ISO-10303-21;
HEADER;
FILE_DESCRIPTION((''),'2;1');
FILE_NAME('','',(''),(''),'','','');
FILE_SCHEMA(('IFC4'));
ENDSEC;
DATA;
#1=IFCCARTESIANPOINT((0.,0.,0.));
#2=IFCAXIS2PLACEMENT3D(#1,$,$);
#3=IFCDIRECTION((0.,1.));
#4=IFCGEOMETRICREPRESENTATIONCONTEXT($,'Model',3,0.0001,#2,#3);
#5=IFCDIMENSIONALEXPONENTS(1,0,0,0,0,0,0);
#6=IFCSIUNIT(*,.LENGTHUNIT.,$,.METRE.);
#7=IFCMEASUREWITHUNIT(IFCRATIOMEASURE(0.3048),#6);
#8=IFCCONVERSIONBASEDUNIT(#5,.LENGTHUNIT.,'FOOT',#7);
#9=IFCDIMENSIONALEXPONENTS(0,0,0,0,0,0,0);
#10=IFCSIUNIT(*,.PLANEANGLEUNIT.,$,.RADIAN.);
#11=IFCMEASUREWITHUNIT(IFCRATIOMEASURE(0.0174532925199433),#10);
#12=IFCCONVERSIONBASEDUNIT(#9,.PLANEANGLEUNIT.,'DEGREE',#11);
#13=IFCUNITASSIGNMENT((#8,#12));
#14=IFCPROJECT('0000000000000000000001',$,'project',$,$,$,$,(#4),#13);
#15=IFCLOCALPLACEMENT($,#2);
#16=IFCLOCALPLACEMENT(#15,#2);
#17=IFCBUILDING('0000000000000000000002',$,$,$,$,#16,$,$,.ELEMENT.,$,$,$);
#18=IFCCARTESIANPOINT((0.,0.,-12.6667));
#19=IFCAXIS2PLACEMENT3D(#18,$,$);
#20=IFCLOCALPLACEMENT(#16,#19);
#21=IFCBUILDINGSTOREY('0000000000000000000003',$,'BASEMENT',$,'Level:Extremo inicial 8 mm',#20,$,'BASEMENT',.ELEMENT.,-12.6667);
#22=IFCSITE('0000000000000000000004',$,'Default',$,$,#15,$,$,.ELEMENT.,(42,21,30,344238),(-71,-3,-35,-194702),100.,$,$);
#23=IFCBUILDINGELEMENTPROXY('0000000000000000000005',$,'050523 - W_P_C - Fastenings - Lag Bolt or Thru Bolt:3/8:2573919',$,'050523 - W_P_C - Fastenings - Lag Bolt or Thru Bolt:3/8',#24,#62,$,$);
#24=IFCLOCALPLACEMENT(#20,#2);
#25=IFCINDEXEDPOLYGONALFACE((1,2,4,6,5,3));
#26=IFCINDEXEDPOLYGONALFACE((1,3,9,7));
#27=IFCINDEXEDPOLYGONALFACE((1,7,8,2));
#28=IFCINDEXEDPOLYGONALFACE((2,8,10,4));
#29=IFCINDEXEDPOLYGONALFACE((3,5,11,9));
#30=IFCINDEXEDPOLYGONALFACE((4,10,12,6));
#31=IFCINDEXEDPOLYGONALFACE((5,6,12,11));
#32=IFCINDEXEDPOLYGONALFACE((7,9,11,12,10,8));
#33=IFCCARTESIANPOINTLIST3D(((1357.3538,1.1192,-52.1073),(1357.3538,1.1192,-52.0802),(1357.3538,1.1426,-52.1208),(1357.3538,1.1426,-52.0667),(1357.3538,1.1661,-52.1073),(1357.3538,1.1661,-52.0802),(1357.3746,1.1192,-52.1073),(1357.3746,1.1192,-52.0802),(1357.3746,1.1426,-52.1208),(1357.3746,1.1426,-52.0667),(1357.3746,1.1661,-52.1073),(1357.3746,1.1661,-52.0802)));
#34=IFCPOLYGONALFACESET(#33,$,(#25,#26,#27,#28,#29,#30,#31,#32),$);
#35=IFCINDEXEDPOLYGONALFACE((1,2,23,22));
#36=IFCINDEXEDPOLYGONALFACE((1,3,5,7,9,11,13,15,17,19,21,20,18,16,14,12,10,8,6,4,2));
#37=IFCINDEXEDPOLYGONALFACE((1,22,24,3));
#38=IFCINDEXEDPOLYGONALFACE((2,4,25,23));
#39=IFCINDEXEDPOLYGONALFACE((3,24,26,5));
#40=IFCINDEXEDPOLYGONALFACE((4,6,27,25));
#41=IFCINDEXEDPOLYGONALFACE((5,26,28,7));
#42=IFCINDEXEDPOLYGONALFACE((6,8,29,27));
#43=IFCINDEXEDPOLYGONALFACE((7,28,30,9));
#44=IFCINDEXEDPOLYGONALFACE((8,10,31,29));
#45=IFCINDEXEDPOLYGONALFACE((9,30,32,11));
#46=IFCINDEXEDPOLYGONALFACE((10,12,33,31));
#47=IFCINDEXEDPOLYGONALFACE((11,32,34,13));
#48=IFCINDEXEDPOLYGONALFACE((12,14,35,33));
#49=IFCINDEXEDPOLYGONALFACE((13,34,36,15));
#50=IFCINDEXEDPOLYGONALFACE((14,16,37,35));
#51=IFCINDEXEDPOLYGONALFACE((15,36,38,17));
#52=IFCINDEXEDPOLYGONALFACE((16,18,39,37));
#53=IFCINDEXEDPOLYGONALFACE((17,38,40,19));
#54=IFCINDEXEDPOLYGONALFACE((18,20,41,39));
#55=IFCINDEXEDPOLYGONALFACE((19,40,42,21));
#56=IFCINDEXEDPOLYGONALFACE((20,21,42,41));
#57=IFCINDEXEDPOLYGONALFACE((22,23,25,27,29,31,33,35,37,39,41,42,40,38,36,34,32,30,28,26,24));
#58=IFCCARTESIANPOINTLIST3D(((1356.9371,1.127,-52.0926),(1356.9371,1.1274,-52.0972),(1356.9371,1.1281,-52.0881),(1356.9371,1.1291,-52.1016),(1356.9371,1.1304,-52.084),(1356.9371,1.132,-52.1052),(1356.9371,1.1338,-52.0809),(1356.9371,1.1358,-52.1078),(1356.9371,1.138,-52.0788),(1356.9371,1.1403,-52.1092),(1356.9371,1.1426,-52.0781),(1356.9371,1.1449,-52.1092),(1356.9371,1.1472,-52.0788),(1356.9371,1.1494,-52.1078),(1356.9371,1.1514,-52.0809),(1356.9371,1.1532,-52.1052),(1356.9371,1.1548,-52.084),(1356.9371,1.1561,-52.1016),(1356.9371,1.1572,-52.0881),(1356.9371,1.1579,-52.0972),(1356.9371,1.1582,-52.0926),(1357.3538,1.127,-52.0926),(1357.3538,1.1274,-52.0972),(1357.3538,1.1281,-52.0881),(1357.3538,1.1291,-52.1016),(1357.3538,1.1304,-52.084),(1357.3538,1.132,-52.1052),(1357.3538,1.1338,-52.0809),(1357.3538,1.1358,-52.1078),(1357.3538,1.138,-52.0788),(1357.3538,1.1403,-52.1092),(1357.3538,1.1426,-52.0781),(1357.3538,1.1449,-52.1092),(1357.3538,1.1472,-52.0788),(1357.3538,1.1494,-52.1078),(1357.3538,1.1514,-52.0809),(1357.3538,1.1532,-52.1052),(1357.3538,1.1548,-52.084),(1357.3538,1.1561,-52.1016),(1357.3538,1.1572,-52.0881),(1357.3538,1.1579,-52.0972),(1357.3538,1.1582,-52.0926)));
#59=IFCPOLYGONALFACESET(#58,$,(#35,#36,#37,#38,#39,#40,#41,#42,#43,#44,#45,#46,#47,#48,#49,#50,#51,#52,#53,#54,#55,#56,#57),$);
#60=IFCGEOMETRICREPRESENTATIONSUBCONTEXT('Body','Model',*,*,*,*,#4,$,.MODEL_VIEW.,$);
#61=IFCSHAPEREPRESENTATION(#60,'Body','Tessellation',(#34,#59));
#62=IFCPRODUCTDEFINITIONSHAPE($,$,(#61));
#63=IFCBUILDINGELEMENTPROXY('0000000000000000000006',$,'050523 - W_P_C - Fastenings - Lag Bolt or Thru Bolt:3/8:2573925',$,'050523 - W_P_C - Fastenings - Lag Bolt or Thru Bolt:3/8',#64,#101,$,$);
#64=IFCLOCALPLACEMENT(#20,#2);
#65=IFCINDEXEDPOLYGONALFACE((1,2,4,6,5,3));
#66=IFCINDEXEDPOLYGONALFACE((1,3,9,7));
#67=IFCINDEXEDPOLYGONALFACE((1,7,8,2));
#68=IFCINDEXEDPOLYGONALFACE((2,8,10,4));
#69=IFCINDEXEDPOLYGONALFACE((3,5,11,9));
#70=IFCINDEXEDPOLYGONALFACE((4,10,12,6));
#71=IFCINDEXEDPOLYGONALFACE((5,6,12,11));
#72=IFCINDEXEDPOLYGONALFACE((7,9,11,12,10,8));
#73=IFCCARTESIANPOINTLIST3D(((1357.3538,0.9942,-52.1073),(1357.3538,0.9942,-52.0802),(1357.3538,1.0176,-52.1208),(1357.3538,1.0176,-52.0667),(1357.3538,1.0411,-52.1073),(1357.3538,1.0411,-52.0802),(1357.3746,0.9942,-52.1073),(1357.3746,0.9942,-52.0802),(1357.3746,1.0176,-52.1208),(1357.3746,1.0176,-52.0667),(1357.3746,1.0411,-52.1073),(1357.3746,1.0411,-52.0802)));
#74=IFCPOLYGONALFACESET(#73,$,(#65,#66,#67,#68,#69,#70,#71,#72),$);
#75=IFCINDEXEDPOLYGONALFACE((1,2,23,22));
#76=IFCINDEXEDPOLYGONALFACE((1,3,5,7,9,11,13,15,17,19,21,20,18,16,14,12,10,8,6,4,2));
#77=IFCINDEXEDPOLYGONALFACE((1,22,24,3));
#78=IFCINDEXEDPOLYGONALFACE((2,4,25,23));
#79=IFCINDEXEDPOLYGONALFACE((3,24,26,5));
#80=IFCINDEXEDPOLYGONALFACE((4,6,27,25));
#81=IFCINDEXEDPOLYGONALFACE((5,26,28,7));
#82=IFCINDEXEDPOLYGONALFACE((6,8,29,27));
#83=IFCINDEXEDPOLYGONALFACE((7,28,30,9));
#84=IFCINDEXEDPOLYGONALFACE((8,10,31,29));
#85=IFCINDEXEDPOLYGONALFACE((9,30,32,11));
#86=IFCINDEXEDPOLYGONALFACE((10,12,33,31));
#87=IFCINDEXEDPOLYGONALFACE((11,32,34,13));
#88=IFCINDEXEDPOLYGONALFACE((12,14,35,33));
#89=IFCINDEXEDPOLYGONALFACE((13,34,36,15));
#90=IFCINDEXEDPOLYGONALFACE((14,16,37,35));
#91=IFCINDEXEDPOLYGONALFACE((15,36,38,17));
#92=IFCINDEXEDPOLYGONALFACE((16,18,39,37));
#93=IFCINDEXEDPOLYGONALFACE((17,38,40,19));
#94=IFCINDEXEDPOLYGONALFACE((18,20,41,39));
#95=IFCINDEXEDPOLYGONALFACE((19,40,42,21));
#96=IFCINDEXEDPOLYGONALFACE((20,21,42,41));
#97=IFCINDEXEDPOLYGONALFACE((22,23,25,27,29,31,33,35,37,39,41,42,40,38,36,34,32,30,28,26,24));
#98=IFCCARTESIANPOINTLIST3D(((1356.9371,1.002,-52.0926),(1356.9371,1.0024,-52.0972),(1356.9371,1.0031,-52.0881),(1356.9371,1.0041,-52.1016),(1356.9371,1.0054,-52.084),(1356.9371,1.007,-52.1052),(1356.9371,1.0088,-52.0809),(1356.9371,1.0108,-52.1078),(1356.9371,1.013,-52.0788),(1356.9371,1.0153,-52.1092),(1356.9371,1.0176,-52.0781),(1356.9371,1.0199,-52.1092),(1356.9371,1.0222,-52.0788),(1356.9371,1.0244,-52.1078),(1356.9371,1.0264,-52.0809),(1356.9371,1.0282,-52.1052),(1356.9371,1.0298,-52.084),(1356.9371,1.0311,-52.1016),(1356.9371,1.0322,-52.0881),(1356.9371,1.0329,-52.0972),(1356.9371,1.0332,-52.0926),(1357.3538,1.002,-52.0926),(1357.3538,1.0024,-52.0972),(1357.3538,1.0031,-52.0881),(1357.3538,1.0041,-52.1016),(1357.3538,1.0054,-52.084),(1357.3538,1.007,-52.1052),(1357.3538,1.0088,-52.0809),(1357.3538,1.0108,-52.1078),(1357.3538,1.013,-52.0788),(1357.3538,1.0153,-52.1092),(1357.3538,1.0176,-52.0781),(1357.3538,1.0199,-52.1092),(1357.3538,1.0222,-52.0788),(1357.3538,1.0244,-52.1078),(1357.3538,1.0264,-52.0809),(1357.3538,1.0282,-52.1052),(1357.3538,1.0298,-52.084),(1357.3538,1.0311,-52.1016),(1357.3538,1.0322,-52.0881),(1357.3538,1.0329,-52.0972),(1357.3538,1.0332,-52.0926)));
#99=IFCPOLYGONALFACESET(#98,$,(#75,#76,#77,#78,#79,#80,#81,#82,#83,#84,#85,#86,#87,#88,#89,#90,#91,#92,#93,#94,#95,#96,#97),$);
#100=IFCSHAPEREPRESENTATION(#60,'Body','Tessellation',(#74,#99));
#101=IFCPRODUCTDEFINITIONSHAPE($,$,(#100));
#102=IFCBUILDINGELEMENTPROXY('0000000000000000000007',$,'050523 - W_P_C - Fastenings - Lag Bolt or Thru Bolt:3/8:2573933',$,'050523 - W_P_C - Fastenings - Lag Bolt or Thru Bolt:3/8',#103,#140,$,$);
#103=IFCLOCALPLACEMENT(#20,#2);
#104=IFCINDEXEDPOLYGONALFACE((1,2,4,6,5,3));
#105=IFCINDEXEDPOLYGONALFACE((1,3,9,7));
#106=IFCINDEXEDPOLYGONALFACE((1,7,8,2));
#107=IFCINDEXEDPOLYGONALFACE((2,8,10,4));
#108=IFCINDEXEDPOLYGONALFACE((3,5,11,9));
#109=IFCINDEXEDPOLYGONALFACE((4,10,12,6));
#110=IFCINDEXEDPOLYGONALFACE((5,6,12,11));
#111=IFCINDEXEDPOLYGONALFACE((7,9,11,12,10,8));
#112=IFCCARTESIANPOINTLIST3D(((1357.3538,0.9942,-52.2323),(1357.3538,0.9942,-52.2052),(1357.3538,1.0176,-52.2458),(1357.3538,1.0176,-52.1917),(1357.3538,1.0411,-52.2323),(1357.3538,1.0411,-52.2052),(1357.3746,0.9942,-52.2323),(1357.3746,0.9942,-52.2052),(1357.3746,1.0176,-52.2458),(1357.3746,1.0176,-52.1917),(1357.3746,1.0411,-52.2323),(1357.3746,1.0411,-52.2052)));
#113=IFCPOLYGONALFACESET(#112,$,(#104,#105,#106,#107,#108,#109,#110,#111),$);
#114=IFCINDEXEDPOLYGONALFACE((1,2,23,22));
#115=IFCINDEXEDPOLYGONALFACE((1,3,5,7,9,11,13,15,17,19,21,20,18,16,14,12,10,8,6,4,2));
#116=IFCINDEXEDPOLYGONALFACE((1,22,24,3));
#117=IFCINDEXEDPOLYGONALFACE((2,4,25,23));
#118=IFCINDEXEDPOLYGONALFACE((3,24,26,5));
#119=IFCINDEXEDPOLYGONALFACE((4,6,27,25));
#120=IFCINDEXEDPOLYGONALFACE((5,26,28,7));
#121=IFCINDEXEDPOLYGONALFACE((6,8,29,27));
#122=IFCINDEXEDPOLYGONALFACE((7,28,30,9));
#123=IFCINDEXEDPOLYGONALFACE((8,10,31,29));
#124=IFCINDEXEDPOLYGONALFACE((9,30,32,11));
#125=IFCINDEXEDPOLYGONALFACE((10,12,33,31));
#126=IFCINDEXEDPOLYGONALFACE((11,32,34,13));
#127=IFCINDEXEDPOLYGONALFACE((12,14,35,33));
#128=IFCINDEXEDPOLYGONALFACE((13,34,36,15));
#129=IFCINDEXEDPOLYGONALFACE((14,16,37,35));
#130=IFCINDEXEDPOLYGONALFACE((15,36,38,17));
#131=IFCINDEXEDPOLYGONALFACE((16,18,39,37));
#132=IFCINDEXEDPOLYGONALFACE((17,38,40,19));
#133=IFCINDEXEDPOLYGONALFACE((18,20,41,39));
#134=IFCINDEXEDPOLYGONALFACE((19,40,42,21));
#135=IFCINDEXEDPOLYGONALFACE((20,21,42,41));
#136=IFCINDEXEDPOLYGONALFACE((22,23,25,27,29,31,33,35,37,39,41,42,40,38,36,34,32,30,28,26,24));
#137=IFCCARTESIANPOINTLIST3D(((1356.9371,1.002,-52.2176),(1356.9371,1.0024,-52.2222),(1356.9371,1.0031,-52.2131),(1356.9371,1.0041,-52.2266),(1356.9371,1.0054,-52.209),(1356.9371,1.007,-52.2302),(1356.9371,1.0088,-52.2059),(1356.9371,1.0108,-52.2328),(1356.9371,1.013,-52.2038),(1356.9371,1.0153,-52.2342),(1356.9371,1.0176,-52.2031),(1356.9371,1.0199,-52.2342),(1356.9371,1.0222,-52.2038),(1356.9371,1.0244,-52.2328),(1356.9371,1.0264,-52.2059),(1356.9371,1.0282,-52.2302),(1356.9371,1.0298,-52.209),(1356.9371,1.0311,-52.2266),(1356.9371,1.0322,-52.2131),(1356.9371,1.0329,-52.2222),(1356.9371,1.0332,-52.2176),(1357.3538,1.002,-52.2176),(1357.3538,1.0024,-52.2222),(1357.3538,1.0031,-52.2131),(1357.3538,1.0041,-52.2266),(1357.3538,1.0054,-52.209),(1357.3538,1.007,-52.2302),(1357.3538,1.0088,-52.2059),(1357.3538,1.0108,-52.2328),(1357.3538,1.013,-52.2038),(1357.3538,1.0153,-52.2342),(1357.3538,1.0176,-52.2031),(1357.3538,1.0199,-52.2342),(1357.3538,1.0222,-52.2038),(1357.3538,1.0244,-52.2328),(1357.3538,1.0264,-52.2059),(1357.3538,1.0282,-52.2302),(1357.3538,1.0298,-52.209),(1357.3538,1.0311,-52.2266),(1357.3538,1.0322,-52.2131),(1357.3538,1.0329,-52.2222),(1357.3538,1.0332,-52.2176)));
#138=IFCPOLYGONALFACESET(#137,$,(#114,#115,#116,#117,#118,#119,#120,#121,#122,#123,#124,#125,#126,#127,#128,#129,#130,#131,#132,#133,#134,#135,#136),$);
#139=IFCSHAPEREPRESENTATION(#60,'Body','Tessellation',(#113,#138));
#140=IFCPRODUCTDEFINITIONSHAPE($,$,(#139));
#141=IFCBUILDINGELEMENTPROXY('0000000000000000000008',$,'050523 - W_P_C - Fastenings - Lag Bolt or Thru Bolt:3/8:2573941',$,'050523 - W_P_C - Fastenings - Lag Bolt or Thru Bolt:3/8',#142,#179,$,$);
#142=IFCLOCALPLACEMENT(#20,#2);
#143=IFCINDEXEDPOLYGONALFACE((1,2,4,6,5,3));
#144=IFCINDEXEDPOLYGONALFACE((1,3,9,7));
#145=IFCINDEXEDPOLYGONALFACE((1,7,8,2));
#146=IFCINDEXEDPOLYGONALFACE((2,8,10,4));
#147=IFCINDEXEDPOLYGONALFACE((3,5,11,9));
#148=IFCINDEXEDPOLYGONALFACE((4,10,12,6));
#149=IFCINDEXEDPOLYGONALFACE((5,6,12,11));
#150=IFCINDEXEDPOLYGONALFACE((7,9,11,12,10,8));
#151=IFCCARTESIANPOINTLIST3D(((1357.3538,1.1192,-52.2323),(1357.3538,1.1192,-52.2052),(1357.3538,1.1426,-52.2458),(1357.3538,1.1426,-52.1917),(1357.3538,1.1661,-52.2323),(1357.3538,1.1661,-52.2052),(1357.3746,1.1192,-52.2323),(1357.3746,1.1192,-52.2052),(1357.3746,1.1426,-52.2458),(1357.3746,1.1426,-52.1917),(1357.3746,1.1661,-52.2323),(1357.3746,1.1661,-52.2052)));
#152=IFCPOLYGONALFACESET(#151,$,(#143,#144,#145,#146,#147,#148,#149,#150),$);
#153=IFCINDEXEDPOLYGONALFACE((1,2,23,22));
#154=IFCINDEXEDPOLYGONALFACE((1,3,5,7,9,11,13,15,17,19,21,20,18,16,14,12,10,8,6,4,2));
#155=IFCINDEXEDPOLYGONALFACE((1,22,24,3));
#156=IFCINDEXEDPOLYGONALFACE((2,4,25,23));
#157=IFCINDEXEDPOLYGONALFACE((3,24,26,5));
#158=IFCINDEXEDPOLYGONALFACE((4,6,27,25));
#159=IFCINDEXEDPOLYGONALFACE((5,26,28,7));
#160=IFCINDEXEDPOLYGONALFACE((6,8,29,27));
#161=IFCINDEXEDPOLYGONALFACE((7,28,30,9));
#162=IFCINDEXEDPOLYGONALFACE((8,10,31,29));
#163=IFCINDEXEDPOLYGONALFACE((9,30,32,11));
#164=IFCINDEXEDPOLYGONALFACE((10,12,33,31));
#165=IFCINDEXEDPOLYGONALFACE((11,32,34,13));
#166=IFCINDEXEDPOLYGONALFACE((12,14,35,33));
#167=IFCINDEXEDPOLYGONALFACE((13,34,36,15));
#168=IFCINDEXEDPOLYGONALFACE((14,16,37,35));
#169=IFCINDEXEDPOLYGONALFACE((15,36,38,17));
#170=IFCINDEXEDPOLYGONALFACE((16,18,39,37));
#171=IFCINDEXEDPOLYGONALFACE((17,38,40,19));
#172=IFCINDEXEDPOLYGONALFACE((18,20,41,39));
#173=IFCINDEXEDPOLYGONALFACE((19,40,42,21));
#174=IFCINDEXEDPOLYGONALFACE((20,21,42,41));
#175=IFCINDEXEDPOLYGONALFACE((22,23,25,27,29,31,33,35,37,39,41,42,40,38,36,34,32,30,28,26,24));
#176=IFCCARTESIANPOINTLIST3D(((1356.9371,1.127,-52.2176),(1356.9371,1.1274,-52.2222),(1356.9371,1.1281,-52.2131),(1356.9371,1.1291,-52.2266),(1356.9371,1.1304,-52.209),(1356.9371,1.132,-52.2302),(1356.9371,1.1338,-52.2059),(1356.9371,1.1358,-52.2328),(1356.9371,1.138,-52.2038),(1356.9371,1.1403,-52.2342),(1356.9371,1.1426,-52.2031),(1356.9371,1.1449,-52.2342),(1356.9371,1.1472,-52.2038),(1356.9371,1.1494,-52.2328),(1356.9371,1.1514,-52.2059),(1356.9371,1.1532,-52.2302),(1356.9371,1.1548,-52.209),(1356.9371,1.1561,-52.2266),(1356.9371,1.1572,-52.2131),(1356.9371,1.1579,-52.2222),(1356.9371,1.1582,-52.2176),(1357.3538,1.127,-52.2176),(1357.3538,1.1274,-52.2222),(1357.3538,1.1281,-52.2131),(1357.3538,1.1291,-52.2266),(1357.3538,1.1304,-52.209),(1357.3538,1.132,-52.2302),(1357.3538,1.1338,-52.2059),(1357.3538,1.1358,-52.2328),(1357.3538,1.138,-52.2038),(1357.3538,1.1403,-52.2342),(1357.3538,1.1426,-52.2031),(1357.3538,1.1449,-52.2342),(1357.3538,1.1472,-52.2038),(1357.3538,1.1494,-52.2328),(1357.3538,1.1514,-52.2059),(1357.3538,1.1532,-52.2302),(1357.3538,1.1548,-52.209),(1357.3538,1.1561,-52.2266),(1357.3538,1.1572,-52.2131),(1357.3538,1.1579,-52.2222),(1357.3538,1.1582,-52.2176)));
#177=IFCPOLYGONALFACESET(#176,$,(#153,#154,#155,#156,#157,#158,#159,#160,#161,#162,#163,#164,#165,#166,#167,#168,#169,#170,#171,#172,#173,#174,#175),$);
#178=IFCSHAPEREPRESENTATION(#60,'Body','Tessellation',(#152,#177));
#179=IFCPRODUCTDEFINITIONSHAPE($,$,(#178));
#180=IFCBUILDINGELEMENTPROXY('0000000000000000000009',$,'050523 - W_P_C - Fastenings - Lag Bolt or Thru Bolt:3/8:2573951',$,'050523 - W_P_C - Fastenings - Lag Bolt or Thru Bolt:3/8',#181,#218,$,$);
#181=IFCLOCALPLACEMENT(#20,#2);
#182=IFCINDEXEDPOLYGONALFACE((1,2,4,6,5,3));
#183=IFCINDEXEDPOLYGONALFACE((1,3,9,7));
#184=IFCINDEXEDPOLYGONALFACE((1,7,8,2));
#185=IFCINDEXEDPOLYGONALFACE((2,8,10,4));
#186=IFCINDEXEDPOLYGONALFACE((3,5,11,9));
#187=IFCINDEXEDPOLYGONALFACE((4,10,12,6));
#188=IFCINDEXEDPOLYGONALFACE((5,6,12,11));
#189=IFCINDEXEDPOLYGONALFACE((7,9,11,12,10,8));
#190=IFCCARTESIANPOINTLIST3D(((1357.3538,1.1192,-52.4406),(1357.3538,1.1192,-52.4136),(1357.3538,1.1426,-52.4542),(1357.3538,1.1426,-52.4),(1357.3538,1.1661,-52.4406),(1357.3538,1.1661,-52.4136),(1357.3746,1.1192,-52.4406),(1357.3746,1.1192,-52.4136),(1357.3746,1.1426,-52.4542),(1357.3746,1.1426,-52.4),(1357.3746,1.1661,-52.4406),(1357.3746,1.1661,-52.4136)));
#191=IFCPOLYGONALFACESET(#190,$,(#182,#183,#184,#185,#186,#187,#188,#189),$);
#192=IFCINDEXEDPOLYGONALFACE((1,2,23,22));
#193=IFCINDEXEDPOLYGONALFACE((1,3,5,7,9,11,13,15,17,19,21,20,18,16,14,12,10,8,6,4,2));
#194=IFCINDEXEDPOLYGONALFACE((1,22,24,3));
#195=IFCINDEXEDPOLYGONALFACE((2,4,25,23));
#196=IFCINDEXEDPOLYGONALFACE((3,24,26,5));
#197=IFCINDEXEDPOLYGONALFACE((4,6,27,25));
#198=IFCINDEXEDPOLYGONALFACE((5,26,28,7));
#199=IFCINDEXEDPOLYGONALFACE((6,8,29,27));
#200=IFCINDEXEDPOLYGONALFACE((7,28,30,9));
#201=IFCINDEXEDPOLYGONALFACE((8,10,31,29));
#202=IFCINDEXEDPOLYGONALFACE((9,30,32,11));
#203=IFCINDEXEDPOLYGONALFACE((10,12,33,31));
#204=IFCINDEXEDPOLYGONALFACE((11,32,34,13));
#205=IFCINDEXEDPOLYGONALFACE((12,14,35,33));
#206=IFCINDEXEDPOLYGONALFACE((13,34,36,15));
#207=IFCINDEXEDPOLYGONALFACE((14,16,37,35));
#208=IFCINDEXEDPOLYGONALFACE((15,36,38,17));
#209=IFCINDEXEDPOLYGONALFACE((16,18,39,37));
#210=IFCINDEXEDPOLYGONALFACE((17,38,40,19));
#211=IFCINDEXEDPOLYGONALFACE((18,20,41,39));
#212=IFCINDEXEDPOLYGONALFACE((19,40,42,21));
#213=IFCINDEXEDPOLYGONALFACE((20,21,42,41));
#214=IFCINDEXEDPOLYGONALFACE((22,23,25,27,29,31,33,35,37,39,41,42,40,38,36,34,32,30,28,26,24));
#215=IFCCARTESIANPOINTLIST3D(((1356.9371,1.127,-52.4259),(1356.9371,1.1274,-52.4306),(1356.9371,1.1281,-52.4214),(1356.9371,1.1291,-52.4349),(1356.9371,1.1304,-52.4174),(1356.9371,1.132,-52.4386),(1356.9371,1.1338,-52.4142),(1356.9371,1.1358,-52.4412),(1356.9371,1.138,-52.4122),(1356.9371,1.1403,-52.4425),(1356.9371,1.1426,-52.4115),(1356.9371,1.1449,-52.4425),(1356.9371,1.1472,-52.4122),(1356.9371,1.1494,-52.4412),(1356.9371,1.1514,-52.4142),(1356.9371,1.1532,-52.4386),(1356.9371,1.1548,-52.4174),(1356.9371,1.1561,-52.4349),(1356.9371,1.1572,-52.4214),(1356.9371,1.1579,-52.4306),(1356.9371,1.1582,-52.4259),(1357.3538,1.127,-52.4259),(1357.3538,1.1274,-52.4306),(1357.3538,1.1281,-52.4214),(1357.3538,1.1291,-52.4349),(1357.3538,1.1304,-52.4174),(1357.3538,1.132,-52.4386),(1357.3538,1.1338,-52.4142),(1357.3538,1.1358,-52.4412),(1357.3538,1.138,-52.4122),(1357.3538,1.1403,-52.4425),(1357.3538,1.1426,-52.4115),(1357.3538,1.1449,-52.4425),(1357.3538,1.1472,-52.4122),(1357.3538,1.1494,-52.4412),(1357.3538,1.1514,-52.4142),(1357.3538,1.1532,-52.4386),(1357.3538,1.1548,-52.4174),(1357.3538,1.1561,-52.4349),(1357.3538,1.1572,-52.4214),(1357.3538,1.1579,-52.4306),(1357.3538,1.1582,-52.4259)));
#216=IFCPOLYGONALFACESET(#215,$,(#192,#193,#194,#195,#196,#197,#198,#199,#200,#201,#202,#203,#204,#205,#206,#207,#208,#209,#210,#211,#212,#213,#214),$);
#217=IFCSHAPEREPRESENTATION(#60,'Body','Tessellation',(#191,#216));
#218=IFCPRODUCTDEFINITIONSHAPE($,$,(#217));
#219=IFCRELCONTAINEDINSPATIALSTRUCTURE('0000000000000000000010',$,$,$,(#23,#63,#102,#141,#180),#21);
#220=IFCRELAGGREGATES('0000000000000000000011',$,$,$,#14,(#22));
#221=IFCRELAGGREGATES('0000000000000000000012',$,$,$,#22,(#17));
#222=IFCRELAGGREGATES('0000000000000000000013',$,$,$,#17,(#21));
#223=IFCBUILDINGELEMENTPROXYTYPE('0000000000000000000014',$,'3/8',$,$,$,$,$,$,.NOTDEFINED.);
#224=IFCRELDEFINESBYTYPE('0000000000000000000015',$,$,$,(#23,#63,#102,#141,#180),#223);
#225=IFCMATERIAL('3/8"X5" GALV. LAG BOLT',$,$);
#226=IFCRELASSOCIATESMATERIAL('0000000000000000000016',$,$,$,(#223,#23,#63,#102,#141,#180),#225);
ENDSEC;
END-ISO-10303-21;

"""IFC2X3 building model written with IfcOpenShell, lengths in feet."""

from ifc_helpers import new_model, entity, si_unit, converted_unit, direction, frame, frame_2d, origin, place, context, subcontext, project, spatial, polyline, circle, outline, extrude, source, transform, mapped, material, type_object, type_shapes, element, save


model = new_model("IFC2X3")

# Units and contexts
model_context = context("Model", 3, precision=0.0001, world=origin(), true_north=direction((0.0, 1.0)))
body_context = subcontext(model_context, "Body", "Model", "MODEL_VIEW")
ifc_project = project(units=[converted_unit("LENGTHUNIT", "FOOT", entity("IfcRatioMeasure", 0.3048), si_unit("LENGTHUNIT", "METRE"), dimensions=[1, 0, 0, 0, 0, 0, 0]), converted_unit("PLANEANGLEUNIT", "DEGREE", entity("IfcRatioMeasure", 0.0174532925199433), si_unit("PLANEANGLEUNIT", "RADIAN"), dimensions=[0, 0, 0, 0, 0, 0, 0])], contexts=[model_context])

# Site, building, storey
site_placement = place(None, origin())
site = spatial("IfcSite", under=ifc_project, at=site_placement, Name="Default", CompositionType="ELEMENT", RefLatitude=(42, 21, 30, 344238), RefLongitude=(-71, -3, -35, -194702), RefElevation=100.0)
building_placement = place(site_placement, origin())
building = spatial("IfcBuilding", under=site, at=building_placement, CompositionType="ELEMENT")
storey_placement = place(building_placement, frame((0.0, 0.0, -12.6667)))
storey = spatial("IfcBuildingStorey", under=building, at=storey_placement, Name="BASEMENT", ObjectType="Level:Extremo inicial 8 mm", LongName="BASEMENT", CompositionType="ELEMENT", Elevation=-12.6667)

# Building element proxies
ifc_material_1 = material(Name="3/8\"X5\" GALV. LAG BOLT")
building_element_proxy_type_1 = type_object("IfcBuildingElementProxyType", Name="3/8", PredefinedType="NOTDEFINED", material=ifc_material_1)
shared_shape_1 = source(origin(), body_context, "Body", "SweptSolid", [
    extrude(outline(polyline([(-0.0135, -0.0234), (0.0135, -0.0234), (0.0271, 0.0), (0.0135, 0.0234), (-0.0135, 0.0234), (-0.0271, 0.0), (-0.0135, -0.0234)])), frame((0.0, 0.0, 0.0), z_axis=(0.0, 0.0, 1.0), x_axis=(0.0, -1.0, 0.0)), (0.0, 0.0, 1.0), 0.0208),
    extrude(circle(Radius=0.0156, at=frame_2d((0.0, 0.0), x_axis=(1.0, 0.0))), frame((0.0, 0.0, -0.4167), z_axis=(0.0, 0.0, 1.0), x_axis=(0.0, 1.0, 0.0)), (0.0, 0.0, 1.0), 0.4167),
])
type_shapes(building_element_proxy_type_1, [shared_shape_1])
for number, where, z_axis, x_axis, name in (
    (1, (1357.3538, 1.1426, -52.0938), (1.0, 0.0, 0.0), (0.0, 1.0, 0.0), "050523 - W_P_C - Fastenings - Lag Bolt or Thru Bolt:3/8:2573919"),
    (2, (1357.3538, 1.0176, -52.0938), (1.0, 0.0, 0.0), (0.0, 1.0, 0.0), "050523 - W_P_C - Fastenings - Lag Bolt or Thru Bolt:3/8:2573925"),
    (3, (1357.3538, 1.0176, -52.2188), (1.0, 0.0, 0.0), (0.0, 1.0, 0.0), "050523 - W_P_C - Fastenings - Lag Bolt or Thru Bolt:3/8:2573933"),
    (4, (1357.3538, 1.1426, -52.2188), (1.0, 0.0, 0.0), (0.0, 1.0, 0.0), "050523 - W_P_C - Fastenings - Lag Bolt or Thru Bolt:3/8:2573941"),
    (5, (1357.3538, 1.1426, -52.4271), (1.0, 0.0, 0.0), (0.0, 1.0, 0.0), "050523 - W_P_C - Fastenings - Lag Bolt or Thru Bolt:3/8:2573951"),
):
    element("IfcBuildingElementProxy", number, at=place(storey_placement, frame(where, z_axis=z_axis, x_axis=x_axis)), inside=storey, type_object=building_element_proxy_type_1, material=ifc_material_1, Name=name, ObjectType="050523 - W_P_C - Fastenings - Lag Bolt or Thru Bolt:3/8", context=body_context, shape_type="MappedRepresentation", body=[
        mapped(shared_shape_1, transform((0.0, 0.0, 0.0), scale=1.0)),
    ])

save(model, "model.ifc")
